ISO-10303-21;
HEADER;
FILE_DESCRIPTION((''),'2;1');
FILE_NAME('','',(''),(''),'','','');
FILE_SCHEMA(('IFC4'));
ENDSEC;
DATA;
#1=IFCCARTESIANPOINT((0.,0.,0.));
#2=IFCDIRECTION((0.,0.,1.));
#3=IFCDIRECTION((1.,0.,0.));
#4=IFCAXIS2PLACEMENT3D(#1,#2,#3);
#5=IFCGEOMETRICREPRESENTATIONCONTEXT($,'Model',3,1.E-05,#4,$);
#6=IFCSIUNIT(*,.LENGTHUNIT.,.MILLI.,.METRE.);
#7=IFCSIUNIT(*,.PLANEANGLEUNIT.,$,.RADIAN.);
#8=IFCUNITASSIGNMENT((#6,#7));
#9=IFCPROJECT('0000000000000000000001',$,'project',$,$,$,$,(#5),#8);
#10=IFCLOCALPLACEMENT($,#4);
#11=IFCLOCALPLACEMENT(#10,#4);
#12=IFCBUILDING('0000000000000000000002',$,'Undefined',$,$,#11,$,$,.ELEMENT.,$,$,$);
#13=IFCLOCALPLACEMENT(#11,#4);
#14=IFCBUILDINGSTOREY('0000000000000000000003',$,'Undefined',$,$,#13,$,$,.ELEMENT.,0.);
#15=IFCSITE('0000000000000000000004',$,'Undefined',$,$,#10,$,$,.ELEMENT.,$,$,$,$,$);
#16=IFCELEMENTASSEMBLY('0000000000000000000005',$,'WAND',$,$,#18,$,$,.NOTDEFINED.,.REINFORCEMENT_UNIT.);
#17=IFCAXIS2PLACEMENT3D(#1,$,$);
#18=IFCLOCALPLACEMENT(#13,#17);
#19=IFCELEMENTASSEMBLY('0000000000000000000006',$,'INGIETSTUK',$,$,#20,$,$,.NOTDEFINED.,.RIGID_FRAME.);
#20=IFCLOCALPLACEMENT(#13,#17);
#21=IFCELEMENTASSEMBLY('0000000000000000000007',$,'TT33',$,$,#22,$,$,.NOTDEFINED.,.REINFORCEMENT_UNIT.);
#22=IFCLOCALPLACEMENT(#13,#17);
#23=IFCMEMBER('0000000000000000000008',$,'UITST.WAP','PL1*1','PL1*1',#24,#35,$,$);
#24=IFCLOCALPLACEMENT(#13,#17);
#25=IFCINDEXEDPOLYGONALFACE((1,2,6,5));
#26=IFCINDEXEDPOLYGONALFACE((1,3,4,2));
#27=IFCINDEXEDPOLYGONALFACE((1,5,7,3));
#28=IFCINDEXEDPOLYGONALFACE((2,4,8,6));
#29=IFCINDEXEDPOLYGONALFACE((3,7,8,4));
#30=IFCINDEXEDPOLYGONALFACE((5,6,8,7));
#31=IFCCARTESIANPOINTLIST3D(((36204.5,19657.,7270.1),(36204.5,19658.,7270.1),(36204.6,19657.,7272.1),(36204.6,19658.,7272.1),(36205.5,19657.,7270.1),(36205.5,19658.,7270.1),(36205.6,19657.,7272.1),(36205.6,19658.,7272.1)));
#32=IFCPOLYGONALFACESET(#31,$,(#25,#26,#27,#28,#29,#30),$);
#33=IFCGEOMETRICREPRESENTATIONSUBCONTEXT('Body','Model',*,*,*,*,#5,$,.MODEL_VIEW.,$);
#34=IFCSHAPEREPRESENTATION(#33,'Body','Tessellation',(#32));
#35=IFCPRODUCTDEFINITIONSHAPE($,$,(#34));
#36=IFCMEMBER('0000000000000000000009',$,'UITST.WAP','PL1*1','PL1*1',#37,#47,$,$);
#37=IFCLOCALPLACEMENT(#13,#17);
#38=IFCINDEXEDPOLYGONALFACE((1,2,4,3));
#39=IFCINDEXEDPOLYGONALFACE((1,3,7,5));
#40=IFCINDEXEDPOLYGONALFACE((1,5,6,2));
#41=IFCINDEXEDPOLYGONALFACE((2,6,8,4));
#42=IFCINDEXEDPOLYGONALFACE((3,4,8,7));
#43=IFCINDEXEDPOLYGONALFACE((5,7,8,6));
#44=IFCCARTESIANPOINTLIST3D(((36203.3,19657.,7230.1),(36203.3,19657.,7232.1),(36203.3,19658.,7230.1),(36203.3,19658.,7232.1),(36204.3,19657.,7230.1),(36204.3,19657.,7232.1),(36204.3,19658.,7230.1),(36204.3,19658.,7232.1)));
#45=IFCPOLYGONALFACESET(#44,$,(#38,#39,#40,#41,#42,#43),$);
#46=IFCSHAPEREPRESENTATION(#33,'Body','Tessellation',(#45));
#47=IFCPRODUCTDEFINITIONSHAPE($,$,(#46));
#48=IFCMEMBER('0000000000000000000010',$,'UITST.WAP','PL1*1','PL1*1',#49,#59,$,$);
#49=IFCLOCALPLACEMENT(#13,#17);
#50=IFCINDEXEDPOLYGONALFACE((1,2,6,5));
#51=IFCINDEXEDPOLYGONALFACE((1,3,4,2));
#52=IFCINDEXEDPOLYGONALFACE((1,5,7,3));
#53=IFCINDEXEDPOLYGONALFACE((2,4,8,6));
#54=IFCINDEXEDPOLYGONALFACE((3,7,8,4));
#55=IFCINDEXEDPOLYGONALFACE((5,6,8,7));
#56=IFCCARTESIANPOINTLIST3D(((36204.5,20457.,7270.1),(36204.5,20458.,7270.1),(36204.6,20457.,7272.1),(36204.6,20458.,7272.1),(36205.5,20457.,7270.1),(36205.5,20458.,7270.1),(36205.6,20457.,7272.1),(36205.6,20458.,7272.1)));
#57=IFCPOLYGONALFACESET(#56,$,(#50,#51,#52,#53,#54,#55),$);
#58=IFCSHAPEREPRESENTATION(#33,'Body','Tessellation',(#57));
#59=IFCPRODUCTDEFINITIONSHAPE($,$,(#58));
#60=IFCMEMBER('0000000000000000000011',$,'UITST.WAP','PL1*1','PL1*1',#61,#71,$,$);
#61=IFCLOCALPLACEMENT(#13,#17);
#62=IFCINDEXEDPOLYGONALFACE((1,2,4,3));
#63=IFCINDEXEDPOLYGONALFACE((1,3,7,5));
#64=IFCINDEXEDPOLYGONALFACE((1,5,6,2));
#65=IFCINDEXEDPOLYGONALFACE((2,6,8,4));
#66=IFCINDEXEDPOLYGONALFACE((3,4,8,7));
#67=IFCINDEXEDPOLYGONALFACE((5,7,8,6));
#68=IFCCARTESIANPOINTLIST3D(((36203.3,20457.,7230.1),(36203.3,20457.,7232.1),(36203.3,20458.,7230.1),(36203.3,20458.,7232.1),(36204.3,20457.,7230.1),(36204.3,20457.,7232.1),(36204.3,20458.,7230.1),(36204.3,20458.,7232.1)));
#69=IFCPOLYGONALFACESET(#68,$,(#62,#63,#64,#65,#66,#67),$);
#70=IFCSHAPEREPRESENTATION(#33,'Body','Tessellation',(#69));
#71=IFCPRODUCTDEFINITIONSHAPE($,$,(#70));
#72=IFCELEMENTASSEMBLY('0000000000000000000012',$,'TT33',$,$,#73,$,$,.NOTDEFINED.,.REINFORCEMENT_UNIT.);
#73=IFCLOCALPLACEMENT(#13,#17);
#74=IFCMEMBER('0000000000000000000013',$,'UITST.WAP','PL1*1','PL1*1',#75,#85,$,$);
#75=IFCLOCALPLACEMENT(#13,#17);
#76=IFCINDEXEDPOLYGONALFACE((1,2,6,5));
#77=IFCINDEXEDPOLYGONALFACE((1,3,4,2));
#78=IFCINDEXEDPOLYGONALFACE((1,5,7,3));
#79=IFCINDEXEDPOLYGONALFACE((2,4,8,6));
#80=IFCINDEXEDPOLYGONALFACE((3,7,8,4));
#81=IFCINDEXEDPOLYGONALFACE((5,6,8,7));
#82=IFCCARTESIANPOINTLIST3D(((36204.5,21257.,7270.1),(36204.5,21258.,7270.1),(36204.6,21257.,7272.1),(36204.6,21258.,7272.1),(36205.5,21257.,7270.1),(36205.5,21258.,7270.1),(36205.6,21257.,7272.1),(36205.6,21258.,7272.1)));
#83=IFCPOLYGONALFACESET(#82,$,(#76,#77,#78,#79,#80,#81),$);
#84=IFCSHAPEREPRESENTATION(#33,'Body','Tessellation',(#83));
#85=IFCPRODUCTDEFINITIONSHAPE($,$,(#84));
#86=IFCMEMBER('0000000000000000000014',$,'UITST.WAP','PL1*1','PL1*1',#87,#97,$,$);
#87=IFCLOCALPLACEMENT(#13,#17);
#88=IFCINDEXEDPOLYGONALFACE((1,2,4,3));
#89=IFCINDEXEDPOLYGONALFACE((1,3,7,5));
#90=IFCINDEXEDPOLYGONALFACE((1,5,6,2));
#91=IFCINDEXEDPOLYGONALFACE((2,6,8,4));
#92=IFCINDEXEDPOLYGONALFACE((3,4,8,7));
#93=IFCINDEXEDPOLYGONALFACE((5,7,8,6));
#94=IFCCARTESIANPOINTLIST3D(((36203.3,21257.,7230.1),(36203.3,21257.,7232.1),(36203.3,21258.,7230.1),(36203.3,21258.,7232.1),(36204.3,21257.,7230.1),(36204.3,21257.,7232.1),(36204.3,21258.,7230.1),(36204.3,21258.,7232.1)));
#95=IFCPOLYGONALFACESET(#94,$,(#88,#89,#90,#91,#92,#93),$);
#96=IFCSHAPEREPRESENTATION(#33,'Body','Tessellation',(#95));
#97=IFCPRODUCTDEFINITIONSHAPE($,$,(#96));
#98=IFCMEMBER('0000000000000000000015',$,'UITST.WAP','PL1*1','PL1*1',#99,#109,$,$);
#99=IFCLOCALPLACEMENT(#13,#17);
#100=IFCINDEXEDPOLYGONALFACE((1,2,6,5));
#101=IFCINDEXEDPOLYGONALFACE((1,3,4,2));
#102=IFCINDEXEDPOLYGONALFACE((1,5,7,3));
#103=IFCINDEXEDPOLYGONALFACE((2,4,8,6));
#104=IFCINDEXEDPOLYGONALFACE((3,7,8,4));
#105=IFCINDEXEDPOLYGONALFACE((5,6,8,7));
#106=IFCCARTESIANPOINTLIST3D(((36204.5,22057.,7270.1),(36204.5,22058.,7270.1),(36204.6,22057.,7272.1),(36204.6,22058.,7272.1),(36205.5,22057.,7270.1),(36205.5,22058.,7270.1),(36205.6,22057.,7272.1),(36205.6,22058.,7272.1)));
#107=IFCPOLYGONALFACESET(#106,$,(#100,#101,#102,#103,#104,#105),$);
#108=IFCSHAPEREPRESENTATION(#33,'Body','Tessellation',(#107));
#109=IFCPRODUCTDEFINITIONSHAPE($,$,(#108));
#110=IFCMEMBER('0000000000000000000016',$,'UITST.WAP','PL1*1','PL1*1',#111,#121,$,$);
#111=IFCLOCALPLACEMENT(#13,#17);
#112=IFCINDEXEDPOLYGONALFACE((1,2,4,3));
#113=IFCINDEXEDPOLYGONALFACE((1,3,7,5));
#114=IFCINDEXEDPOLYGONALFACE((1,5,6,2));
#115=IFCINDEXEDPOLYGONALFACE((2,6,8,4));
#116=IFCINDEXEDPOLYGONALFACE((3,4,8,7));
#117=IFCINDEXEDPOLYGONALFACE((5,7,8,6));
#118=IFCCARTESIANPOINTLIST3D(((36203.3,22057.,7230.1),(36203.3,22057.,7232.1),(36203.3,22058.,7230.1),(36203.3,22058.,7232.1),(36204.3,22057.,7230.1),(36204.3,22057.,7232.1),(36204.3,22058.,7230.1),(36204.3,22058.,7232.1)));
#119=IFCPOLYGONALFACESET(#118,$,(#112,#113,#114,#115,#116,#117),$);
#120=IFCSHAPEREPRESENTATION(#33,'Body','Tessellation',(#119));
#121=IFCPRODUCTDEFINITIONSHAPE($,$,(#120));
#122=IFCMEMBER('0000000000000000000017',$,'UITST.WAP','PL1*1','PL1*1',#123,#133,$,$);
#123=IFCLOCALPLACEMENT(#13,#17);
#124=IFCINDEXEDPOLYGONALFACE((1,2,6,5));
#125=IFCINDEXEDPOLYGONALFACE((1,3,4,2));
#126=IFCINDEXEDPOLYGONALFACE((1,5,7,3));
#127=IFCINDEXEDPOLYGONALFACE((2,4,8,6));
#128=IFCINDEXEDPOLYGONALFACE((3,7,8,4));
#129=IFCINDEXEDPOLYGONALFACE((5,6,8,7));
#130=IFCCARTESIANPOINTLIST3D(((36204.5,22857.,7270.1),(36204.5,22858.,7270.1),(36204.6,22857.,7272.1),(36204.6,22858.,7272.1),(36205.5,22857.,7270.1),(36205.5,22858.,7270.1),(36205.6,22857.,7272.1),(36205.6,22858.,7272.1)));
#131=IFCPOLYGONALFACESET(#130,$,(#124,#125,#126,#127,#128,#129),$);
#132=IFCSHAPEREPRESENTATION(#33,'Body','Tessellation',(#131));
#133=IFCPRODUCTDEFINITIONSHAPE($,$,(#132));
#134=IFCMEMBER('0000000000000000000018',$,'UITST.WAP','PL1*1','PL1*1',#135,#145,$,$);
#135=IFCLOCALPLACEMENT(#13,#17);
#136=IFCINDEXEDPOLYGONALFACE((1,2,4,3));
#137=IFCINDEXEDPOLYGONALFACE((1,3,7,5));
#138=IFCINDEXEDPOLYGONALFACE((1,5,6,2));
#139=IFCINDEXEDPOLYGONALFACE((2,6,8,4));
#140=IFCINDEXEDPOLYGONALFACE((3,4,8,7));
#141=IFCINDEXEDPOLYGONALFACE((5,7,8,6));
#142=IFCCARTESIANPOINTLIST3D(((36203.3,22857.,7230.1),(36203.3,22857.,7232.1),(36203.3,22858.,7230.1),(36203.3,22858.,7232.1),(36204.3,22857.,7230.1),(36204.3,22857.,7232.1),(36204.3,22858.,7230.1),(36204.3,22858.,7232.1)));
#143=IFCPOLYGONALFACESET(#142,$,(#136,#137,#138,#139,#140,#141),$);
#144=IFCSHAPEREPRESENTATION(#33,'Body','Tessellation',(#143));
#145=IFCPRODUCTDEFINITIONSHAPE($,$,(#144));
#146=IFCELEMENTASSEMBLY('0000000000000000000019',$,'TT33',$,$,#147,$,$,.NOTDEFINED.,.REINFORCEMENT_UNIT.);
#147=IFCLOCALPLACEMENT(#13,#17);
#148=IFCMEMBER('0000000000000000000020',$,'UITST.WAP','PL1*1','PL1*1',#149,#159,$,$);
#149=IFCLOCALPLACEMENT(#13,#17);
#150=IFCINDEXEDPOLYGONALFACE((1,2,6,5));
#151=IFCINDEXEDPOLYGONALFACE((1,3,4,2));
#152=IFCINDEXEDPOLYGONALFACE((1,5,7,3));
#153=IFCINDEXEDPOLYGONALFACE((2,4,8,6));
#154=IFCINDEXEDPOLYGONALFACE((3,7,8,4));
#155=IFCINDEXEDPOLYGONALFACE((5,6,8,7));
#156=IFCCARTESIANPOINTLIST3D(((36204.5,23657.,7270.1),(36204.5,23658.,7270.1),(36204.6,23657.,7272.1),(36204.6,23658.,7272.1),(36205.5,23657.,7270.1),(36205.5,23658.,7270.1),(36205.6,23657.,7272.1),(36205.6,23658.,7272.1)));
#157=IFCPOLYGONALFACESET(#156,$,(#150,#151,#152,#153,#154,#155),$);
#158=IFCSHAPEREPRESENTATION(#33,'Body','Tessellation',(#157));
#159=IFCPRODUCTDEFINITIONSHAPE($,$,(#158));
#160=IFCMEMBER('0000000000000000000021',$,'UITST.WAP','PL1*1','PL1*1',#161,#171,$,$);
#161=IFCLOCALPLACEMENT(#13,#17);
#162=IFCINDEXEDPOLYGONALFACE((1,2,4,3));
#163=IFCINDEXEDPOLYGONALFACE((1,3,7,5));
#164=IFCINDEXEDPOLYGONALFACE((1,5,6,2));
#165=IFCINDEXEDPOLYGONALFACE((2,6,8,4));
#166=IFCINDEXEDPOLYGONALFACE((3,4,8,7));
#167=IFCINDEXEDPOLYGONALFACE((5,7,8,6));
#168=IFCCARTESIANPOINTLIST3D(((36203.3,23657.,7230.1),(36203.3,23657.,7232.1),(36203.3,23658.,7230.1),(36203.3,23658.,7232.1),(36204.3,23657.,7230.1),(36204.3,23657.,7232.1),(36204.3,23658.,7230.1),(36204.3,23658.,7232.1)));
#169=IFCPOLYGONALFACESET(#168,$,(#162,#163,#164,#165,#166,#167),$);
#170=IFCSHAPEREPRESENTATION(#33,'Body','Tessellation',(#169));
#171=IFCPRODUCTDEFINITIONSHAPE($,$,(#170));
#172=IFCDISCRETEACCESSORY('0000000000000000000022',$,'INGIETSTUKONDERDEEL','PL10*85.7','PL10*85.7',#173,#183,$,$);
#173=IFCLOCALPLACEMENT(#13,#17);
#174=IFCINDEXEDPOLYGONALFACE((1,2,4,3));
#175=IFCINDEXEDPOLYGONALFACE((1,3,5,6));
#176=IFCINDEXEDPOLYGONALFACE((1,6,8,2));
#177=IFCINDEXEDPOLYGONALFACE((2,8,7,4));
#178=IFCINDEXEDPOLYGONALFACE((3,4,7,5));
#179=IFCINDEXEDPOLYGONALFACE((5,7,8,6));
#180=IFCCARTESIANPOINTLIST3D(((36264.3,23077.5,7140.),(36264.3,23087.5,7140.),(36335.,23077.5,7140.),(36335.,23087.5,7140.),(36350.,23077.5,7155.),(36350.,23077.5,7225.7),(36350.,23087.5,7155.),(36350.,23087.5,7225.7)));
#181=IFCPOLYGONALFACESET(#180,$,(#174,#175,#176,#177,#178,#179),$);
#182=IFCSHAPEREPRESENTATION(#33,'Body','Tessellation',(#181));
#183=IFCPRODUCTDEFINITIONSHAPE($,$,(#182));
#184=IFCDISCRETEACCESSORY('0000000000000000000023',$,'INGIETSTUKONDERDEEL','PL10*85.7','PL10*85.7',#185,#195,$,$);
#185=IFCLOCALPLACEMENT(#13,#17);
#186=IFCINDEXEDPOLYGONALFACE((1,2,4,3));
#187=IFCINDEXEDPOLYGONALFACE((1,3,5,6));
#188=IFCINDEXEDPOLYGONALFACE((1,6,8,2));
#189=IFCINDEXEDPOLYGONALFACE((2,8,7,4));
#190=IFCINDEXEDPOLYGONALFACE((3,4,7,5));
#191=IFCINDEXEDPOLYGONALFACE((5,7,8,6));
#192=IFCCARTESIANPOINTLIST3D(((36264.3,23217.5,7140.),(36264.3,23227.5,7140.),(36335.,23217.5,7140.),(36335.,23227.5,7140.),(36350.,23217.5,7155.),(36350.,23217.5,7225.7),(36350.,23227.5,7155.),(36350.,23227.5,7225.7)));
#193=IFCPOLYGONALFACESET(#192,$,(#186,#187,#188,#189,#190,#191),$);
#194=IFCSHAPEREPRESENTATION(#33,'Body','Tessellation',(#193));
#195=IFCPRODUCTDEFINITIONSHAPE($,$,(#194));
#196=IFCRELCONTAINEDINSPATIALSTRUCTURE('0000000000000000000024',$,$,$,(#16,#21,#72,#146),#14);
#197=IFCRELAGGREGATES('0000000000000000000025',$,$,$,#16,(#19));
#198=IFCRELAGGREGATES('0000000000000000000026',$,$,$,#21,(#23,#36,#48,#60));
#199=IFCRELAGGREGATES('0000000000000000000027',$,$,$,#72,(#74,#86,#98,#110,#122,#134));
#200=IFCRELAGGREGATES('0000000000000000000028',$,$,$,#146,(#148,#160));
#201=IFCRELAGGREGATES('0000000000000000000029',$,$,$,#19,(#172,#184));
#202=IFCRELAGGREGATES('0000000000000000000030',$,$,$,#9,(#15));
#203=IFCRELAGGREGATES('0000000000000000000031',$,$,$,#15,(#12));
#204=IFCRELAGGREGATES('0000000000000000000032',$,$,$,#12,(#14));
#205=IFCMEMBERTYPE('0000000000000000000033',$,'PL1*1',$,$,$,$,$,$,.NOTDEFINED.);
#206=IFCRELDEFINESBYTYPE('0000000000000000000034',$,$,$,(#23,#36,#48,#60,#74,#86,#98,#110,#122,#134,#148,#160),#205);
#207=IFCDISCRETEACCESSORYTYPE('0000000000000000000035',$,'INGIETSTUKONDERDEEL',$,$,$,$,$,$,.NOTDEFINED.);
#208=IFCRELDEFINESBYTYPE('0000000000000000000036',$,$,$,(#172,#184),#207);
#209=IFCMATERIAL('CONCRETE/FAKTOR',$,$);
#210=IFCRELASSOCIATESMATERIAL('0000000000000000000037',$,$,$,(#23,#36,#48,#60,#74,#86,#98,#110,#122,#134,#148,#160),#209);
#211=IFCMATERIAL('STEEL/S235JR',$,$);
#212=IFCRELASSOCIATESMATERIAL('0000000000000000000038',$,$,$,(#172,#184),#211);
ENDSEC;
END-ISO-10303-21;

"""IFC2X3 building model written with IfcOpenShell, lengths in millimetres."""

from ifc_helpers import new_model, si_unit, frame, frame_2d, origin_with_axes, place, context, subcontext, project, spatial, polyline, rectangle, outline, extrude, material, type_object, element, aggregate, save


model = new_model("IFC2X3")

# Units and contexts
model_context = context("Model", 3, precision=1e-05, world=origin_with_axes())
body_context = subcontext(model_context, "Body", "Model", "MODEL_VIEW")
ifc_project = project(units=[si_unit("LENGTHUNIT", "METRE", prefix="MILLI"), si_unit("PLANEANGLEUNIT", "RADIAN")], contexts=[model_context])

# Site, building, storey
site_placement = place(None, origin_with_axes())
site = spatial("IfcSite", under=ifc_project, at=site_placement, Name="Undefined", CompositionType="ELEMENT")
building_placement = place(site_placement, origin_with_axes())
building = spatial("IfcBuilding", under=site, at=building_placement, Name="Undefined", CompositionType="ELEMENT")
storey_placement = place(building_placement, origin_with_axes())
storey = spatial("IfcBuildingStorey", under=building, at=storey_placement, Name="Undefined", CompositionType="ELEMENT", Elevation=0.0)

# Shared definitions
ifc_material_1 = material(Name="CONCRETE/FAKTOR")

# Element assemblies
assembly_1_placement = place(storey_placement, origin_with_axes())
assembly_1 = element("IfcElementAssembly", 1, at=assembly_1_placement, inside=storey, Name="WAND", AssemblyPlace="NOTDEFINED", PredefinedType="REINFORCEMENT_UNIT")
assembly_2_placement = place(assembly_1_placement, origin_with_axes())
assembly_2 = element("IfcElementAssembly", 2, at=assembly_2_placement, Name="INGIETSTUK", AssemblyPlace="NOTDEFINED", PredefinedType="RIGID_FRAME")
ifc_material_2 = material(Name="STEEL/S235JR")

aggregate(assembly_1, [assembly_2])

# Element assemblies, members
assembly_3_placement = place(storey_placement, origin_with_axes())
assembly_3 = element("IfcElementAssembly", 3, at=assembly_3_placement, inside=storey, Name="TT33", AssemblyPlace="NOTDEFINED", PredefinedType="REINFORCEMENT_UNIT")
member_type = type_object("IfcMemberType", Name="PL1*1", PredefinedType="NOTDEFINED")
member_1_placement = place(assembly_3_placement, frame((36205.0, 19657.5, 7270.1), z_axis=(0.0, -1.0, 0.0), x_axis=(0.031107, 0.0, 0.999516)))
member_1 = element("IfcMember", 4, at=member_1_placement, type_object=member_type, material=ifc_material_1, Name="UITST.WAP", Description="PL1*1", ObjectType="PL1*1", context=body_context, shape_type="SweptSolid", body=[
    extrude(rectangle(XDim=1.0, YDim=1.0, at=frame_2d((0.0, 0.0), x_axis=(1.0, 0.0))), frame((2.0, 0.0, 0.0), z_axis=(-1.0, 0.0, 0.0), x_axis=(0.0, -1.0, 0.0)), (0.0, 0.0, 1.0), 2.0),
])
member_2_placement = place(assembly_3_placement, frame((36203.8, 19657.5, 7230.1), z_axis=(0.0, -1.0, 0.0), x_axis=(0.031107, 0.0, 0.999516)))
member_2 = element("IfcMember", 5, at=member_2_placement, type_object=member_type, material=ifc_material_1, Name="UITST.WAP", Description="PL1*1", ObjectType="PL1*1", context=body_context, shape_type="SweptSolid", body=[
    extrude(rectangle(XDim=1.0, YDim=1.0, at=frame_2d((0.0, 0.0), x_axis=(1.0, 0.0))), frame((2.0, 0.0, 0.0), z_axis=(-1.0, 0.0, 0.0), x_axis=(0.0, -1.0, 0.0)), (0.0, 0.0, 1.0), 2.0),
])
member_3_placement = place(assembly_3_placement, frame((36205.0, 20457.5, 7270.1), z_axis=(0.0, -1.0, 0.0), x_axis=(0.031107, 0.0, 0.999516)))
member_3 = element("IfcMember", 6, at=member_3_placement, type_object=member_type, material=ifc_material_1, Name="UITST.WAP", Description="PL1*1", ObjectType="PL1*1", context=body_context, shape_type="SweptSolid", body=[
    extrude(rectangle(XDim=1.0, YDim=1.0, at=frame_2d((0.0, 0.0), x_axis=(1.0, 0.0))), frame((2.0, 0.0, 0.0), z_axis=(-1.0, 0.0, 0.0), x_axis=(0.0, -1.0, 0.0)), (0.0, 0.0, 1.0), 2.0),
])
member_4_placement = place(assembly_3_placement, frame((36203.8, 20457.5, 7230.1), z_axis=(0.0, -1.0, 0.0), x_axis=(0.031107, 0.0, 0.999516)))
member_4 = element("IfcMember", 7, at=member_4_placement, type_object=member_type, material=ifc_material_1, Name="UITST.WAP", Description="PL1*1", ObjectType="PL1*1", context=body_context, shape_type="SweptSolid", body=[
    extrude(rectangle(XDim=1.0, YDim=1.0, at=frame_2d((0.0, 0.0), x_axis=(1.0, 0.0))), frame((2.0, 0.0, 0.0), z_axis=(-1.0, 0.0, 0.0), x_axis=(0.0, -1.0, 0.0)), (0.0, 0.0, 1.0), 2.0),
])
aggregate(assembly_3, [member_1, member_2, member_3, member_4])
assembly_4_placement = place(storey_placement, origin_with_axes())
assembly_4 = element("IfcElementAssembly", 8, at=assembly_4_placement, inside=storey, Name="TT33", AssemblyPlace="NOTDEFINED", PredefinedType="REINFORCEMENT_UNIT")
member_5_placement = place(assembly_4_placement, frame((36205.0, 21257.5, 7270.1), z_axis=(0.0, -1.0, 0.0), x_axis=(0.031107, 0.0, 0.999516)))
member_5 = element("IfcMember", 9, at=member_5_placement, type_object=member_type, material=ifc_material_1, Name="UITST.WAP", Description="PL1*1", ObjectType="PL1*1", context=body_context, shape_type="SweptSolid", body=[
    extrude(rectangle(XDim=1.0, YDim=1.0, at=frame_2d((0.0, 0.0), x_axis=(1.0, 0.0))), frame((2.0, 0.0, 0.0), z_axis=(-1.0, 0.0, 0.0), x_axis=(0.0, -1.0, 0.0)), (0.0, 0.0, 1.0), 2.0),
])
member_6_placement = place(assembly_4_placement, frame((36203.8, 21257.5, 7230.1), z_axis=(0.0, -1.0, 0.0), x_axis=(0.031107, 0.0, 0.999516)))
member_6 = element("IfcMember", 10, at=member_6_placement, type_object=member_type, material=ifc_material_1, Name="UITST.WAP", Description="PL1*1", ObjectType="PL1*1", context=body_context, shape_type="SweptSolid", body=[
    extrude(rectangle(XDim=1.0, YDim=1.0, at=frame_2d((0.0, 0.0), x_axis=(1.0, 0.0))), frame((2.0, 0.0, 0.0), z_axis=(-1.0, 0.0, 0.0), x_axis=(0.0, -1.0, 0.0)), (0.0, 0.0, 1.0), 2.0),
])
member_7_placement = place(assembly_4_placement, frame((36205.0, 22057.5, 7270.1), z_axis=(0.0, -1.0, 0.0), x_axis=(0.031107, 0.0, 0.999516)))
member_7 = element("IfcMember", 11, at=member_7_placement, type_object=member_type, material=ifc_material_1, Name="UITST.WAP", Description="PL1*1", ObjectType="PL1*1", context=body_context, shape_type="SweptSolid", body=[
    extrude(rectangle(XDim=1.0, YDim=1.0, at=frame_2d((0.0, 0.0), x_axis=(1.0, 0.0))), frame((2.0, 0.0, 0.0), z_axis=(-1.0, 0.0, 0.0), x_axis=(0.0, -1.0, 0.0)), (0.0, 0.0, 1.0), 2.0),
])
member_8_placement = place(assembly_4_placement, frame((36203.8, 22057.5, 7230.1), z_axis=(0.0, -1.0, 0.0), x_axis=(0.031107, 0.0, 0.999516)))
member_8 = element("IfcMember", 12, at=member_8_placement, type_object=member_type, material=ifc_material_1, Name="UITST.WAP", Description="PL1*1", ObjectType="PL1*1", context=body_context, shape_type="SweptSolid", body=[
    extrude(rectangle(XDim=1.0, YDim=1.0, at=frame_2d((0.0, 0.0), x_axis=(1.0, 0.0))), frame((2.0, 0.0, 0.0), z_axis=(-1.0, 0.0, 0.0), x_axis=(0.0, -1.0, 0.0)), (0.0, 0.0, 1.0), 2.0),
])
member_9_placement = place(assembly_4_placement, frame((36205.0, 22857.5, 7270.1), z_axis=(0.0, -1.0, 0.0), x_axis=(0.031107, 0.0, 0.999516)))
member_9 = element("IfcMember", 13, at=member_9_placement, type_object=member_type, material=ifc_material_1, Name="UITST.WAP", Description="PL1*1", ObjectType="PL1*1", context=body_context, shape_type="SweptSolid", body=[
    extrude(rectangle(XDim=1.0, YDim=1.0, at=frame_2d((0.0, 0.0), x_axis=(1.0, 0.0))), frame((2.0, 0.0, 0.0), z_axis=(-1.0, 0.0, 0.0), x_axis=(0.0, -1.0, 0.0)), (0.0, 0.0, 1.0), 2.0),
])
member_10_placement = place(assembly_4_placement, frame((36203.8, 22857.5, 7230.1), z_axis=(0.0, -1.0, 0.0), x_axis=(0.031107, 0.0, 0.999516)))
member_10 = element("IfcMember", 14, at=member_10_placement, type_object=member_type, material=ifc_material_1, Name="UITST.WAP", Description="PL1*1", ObjectType="PL1*1", context=body_context, shape_type="SweptSolid", body=[
    extrude(rectangle(XDim=1.0, YDim=1.0, at=frame_2d((0.0, 0.0), x_axis=(1.0, 0.0))), frame((2.0, 0.0, 0.0), z_axis=(-1.0, 0.0, 0.0), x_axis=(0.0, -1.0, 0.0)), (0.0, 0.0, 1.0), 2.0),
])
aggregate(assembly_4, [member_5, member_6, member_7, member_8, member_9, member_10])
assembly_5_placement = place(storey_placement, origin_with_axes())
assembly_5 = element("IfcElementAssembly", 15, at=assembly_5_placement, inside=storey, Name="TT33", AssemblyPlace="NOTDEFINED", PredefinedType="REINFORCEMENT_UNIT")
member_11_placement = place(assembly_5_placement, frame((36205.0, 23657.5, 7270.1), z_axis=(0.0, -1.0, 0.0), x_axis=(0.031107, 0.0, 0.999516)))
member_11 = element("IfcMember", 16, at=member_11_placement, type_object=member_type, material=ifc_material_1, Name="UITST.WAP", Description="PL1*1", ObjectType="PL1*1", context=body_context, shape_type="SweptSolid", body=[
    extrude(rectangle(XDim=1.0, YDim=1.0, at=frame_2d((0.0, 0.0), x_axis=(1.0, 0.0))), frame((2.0, 0.0, 0.0), z_axis=(-1.0, 0.0, 0.0), x_axis=(0.0, -1.0, 0.0)), (0.0, 0.0, 1.0), 2.0),
])
member_12_placement = place(assembly_5_placement, frame((36203.8, 23657.5, 7230.1), z_axis=(0.0, -1.0, 0.0), x_axis=(0.031107, 0.0, 0.999516)))
member_12 = element("IfcMember", 17, at=member_12_placement, type_object=member_type, material=ifc_material_1, Name="UITST.WAP", Description="PL1*1", ObjectType="PL1*1", context=body_context, shape_type="SweptSolid", body=[
    extrude(rectangle(XDim=1.0, YDim=1.0, at=frame_2d((0.0, 0.0), x_axis=(1.0, 0.0))), frame((2.0, 0.0, 0.0), z_axis=(-1.0, 0.0, 0.0), x_axis=(0.0, -1.0, 0.0)), (0.0, 0.0, 1.0), 2.0),
])
aggregate(assembly_5, [member_11, member_12])

# Discrete accessories
discrete_accessory_type = type_object("IfcDiscreteAccessoryType", Name="INGIETSTUKONDERDEEL")
discrete_accessory_1_placement = place(assembly_2_placement, frame((36350.0, 23082.5, 7225.7), z_axis=(0.0, 1.0, 0.0), x_axis=(0.0, 0.0, -1.0)))
discrete_accessory_1 = element("IfcDiscreteAccessory", 18, at=discrete_accessory_1_placement, type_object=discrete_accessory_type, material=ifc_material_2, Name="INGIETSTUKONDERDEEL", Description="PL10*85.7", ObjectType="PL10*85.7", context=body_context, shape_type="SweptSolid", body=[
    extrude(outline(polyline([(0.0, 0.0), (70.7, 0.0), (85.7, 15.0), (85.7, 85.7), (0.0, 0.0)])), frame((0.0, 0.0, -5.0), z_axis=(0.0, 0.0, 1.0), x_axis=(1.0, 0.0, 0.0)), (0.0, 0.0, 1.0), 10.0),
])
discrete_accessory_2_placement = place(assembly_2_placement, frame((36350.0, 23222.5, 7225.7), z_axis=(0.0, 1.0, 0.0), x_axis=(0.0, 0.0, -1.0)))
discrete_accessory_2 = element("IfcDiscreteAccessory", 19, at=discrete_accessory_2_placement, type_object=discrete_accessory_type, material=ifc_material_2, Name="INGIETSTUKONDERDEEL", Description="PL10*85.7", ObjectType="PL10*85.7", context=body_context, shape_type="SweptSolid", body=[
    extrude(outline(polyline([(0.0, 0.0), (70.7, 0.0), (85.7, 15.0), (85.7, 85.7), (0.0, 0.0)])), frame((0.0, 0.0, -5.0), z_axis=(0.0, 0.0, 1.0), x_axis=(1.0, 0.0, 0.0)), (0.0, 0.0, 1.0), 10.0),
])
aggregate(assembly_2, [discrete_accessory_1, discrete_accessory_2])

save(model, "model.ifc")
